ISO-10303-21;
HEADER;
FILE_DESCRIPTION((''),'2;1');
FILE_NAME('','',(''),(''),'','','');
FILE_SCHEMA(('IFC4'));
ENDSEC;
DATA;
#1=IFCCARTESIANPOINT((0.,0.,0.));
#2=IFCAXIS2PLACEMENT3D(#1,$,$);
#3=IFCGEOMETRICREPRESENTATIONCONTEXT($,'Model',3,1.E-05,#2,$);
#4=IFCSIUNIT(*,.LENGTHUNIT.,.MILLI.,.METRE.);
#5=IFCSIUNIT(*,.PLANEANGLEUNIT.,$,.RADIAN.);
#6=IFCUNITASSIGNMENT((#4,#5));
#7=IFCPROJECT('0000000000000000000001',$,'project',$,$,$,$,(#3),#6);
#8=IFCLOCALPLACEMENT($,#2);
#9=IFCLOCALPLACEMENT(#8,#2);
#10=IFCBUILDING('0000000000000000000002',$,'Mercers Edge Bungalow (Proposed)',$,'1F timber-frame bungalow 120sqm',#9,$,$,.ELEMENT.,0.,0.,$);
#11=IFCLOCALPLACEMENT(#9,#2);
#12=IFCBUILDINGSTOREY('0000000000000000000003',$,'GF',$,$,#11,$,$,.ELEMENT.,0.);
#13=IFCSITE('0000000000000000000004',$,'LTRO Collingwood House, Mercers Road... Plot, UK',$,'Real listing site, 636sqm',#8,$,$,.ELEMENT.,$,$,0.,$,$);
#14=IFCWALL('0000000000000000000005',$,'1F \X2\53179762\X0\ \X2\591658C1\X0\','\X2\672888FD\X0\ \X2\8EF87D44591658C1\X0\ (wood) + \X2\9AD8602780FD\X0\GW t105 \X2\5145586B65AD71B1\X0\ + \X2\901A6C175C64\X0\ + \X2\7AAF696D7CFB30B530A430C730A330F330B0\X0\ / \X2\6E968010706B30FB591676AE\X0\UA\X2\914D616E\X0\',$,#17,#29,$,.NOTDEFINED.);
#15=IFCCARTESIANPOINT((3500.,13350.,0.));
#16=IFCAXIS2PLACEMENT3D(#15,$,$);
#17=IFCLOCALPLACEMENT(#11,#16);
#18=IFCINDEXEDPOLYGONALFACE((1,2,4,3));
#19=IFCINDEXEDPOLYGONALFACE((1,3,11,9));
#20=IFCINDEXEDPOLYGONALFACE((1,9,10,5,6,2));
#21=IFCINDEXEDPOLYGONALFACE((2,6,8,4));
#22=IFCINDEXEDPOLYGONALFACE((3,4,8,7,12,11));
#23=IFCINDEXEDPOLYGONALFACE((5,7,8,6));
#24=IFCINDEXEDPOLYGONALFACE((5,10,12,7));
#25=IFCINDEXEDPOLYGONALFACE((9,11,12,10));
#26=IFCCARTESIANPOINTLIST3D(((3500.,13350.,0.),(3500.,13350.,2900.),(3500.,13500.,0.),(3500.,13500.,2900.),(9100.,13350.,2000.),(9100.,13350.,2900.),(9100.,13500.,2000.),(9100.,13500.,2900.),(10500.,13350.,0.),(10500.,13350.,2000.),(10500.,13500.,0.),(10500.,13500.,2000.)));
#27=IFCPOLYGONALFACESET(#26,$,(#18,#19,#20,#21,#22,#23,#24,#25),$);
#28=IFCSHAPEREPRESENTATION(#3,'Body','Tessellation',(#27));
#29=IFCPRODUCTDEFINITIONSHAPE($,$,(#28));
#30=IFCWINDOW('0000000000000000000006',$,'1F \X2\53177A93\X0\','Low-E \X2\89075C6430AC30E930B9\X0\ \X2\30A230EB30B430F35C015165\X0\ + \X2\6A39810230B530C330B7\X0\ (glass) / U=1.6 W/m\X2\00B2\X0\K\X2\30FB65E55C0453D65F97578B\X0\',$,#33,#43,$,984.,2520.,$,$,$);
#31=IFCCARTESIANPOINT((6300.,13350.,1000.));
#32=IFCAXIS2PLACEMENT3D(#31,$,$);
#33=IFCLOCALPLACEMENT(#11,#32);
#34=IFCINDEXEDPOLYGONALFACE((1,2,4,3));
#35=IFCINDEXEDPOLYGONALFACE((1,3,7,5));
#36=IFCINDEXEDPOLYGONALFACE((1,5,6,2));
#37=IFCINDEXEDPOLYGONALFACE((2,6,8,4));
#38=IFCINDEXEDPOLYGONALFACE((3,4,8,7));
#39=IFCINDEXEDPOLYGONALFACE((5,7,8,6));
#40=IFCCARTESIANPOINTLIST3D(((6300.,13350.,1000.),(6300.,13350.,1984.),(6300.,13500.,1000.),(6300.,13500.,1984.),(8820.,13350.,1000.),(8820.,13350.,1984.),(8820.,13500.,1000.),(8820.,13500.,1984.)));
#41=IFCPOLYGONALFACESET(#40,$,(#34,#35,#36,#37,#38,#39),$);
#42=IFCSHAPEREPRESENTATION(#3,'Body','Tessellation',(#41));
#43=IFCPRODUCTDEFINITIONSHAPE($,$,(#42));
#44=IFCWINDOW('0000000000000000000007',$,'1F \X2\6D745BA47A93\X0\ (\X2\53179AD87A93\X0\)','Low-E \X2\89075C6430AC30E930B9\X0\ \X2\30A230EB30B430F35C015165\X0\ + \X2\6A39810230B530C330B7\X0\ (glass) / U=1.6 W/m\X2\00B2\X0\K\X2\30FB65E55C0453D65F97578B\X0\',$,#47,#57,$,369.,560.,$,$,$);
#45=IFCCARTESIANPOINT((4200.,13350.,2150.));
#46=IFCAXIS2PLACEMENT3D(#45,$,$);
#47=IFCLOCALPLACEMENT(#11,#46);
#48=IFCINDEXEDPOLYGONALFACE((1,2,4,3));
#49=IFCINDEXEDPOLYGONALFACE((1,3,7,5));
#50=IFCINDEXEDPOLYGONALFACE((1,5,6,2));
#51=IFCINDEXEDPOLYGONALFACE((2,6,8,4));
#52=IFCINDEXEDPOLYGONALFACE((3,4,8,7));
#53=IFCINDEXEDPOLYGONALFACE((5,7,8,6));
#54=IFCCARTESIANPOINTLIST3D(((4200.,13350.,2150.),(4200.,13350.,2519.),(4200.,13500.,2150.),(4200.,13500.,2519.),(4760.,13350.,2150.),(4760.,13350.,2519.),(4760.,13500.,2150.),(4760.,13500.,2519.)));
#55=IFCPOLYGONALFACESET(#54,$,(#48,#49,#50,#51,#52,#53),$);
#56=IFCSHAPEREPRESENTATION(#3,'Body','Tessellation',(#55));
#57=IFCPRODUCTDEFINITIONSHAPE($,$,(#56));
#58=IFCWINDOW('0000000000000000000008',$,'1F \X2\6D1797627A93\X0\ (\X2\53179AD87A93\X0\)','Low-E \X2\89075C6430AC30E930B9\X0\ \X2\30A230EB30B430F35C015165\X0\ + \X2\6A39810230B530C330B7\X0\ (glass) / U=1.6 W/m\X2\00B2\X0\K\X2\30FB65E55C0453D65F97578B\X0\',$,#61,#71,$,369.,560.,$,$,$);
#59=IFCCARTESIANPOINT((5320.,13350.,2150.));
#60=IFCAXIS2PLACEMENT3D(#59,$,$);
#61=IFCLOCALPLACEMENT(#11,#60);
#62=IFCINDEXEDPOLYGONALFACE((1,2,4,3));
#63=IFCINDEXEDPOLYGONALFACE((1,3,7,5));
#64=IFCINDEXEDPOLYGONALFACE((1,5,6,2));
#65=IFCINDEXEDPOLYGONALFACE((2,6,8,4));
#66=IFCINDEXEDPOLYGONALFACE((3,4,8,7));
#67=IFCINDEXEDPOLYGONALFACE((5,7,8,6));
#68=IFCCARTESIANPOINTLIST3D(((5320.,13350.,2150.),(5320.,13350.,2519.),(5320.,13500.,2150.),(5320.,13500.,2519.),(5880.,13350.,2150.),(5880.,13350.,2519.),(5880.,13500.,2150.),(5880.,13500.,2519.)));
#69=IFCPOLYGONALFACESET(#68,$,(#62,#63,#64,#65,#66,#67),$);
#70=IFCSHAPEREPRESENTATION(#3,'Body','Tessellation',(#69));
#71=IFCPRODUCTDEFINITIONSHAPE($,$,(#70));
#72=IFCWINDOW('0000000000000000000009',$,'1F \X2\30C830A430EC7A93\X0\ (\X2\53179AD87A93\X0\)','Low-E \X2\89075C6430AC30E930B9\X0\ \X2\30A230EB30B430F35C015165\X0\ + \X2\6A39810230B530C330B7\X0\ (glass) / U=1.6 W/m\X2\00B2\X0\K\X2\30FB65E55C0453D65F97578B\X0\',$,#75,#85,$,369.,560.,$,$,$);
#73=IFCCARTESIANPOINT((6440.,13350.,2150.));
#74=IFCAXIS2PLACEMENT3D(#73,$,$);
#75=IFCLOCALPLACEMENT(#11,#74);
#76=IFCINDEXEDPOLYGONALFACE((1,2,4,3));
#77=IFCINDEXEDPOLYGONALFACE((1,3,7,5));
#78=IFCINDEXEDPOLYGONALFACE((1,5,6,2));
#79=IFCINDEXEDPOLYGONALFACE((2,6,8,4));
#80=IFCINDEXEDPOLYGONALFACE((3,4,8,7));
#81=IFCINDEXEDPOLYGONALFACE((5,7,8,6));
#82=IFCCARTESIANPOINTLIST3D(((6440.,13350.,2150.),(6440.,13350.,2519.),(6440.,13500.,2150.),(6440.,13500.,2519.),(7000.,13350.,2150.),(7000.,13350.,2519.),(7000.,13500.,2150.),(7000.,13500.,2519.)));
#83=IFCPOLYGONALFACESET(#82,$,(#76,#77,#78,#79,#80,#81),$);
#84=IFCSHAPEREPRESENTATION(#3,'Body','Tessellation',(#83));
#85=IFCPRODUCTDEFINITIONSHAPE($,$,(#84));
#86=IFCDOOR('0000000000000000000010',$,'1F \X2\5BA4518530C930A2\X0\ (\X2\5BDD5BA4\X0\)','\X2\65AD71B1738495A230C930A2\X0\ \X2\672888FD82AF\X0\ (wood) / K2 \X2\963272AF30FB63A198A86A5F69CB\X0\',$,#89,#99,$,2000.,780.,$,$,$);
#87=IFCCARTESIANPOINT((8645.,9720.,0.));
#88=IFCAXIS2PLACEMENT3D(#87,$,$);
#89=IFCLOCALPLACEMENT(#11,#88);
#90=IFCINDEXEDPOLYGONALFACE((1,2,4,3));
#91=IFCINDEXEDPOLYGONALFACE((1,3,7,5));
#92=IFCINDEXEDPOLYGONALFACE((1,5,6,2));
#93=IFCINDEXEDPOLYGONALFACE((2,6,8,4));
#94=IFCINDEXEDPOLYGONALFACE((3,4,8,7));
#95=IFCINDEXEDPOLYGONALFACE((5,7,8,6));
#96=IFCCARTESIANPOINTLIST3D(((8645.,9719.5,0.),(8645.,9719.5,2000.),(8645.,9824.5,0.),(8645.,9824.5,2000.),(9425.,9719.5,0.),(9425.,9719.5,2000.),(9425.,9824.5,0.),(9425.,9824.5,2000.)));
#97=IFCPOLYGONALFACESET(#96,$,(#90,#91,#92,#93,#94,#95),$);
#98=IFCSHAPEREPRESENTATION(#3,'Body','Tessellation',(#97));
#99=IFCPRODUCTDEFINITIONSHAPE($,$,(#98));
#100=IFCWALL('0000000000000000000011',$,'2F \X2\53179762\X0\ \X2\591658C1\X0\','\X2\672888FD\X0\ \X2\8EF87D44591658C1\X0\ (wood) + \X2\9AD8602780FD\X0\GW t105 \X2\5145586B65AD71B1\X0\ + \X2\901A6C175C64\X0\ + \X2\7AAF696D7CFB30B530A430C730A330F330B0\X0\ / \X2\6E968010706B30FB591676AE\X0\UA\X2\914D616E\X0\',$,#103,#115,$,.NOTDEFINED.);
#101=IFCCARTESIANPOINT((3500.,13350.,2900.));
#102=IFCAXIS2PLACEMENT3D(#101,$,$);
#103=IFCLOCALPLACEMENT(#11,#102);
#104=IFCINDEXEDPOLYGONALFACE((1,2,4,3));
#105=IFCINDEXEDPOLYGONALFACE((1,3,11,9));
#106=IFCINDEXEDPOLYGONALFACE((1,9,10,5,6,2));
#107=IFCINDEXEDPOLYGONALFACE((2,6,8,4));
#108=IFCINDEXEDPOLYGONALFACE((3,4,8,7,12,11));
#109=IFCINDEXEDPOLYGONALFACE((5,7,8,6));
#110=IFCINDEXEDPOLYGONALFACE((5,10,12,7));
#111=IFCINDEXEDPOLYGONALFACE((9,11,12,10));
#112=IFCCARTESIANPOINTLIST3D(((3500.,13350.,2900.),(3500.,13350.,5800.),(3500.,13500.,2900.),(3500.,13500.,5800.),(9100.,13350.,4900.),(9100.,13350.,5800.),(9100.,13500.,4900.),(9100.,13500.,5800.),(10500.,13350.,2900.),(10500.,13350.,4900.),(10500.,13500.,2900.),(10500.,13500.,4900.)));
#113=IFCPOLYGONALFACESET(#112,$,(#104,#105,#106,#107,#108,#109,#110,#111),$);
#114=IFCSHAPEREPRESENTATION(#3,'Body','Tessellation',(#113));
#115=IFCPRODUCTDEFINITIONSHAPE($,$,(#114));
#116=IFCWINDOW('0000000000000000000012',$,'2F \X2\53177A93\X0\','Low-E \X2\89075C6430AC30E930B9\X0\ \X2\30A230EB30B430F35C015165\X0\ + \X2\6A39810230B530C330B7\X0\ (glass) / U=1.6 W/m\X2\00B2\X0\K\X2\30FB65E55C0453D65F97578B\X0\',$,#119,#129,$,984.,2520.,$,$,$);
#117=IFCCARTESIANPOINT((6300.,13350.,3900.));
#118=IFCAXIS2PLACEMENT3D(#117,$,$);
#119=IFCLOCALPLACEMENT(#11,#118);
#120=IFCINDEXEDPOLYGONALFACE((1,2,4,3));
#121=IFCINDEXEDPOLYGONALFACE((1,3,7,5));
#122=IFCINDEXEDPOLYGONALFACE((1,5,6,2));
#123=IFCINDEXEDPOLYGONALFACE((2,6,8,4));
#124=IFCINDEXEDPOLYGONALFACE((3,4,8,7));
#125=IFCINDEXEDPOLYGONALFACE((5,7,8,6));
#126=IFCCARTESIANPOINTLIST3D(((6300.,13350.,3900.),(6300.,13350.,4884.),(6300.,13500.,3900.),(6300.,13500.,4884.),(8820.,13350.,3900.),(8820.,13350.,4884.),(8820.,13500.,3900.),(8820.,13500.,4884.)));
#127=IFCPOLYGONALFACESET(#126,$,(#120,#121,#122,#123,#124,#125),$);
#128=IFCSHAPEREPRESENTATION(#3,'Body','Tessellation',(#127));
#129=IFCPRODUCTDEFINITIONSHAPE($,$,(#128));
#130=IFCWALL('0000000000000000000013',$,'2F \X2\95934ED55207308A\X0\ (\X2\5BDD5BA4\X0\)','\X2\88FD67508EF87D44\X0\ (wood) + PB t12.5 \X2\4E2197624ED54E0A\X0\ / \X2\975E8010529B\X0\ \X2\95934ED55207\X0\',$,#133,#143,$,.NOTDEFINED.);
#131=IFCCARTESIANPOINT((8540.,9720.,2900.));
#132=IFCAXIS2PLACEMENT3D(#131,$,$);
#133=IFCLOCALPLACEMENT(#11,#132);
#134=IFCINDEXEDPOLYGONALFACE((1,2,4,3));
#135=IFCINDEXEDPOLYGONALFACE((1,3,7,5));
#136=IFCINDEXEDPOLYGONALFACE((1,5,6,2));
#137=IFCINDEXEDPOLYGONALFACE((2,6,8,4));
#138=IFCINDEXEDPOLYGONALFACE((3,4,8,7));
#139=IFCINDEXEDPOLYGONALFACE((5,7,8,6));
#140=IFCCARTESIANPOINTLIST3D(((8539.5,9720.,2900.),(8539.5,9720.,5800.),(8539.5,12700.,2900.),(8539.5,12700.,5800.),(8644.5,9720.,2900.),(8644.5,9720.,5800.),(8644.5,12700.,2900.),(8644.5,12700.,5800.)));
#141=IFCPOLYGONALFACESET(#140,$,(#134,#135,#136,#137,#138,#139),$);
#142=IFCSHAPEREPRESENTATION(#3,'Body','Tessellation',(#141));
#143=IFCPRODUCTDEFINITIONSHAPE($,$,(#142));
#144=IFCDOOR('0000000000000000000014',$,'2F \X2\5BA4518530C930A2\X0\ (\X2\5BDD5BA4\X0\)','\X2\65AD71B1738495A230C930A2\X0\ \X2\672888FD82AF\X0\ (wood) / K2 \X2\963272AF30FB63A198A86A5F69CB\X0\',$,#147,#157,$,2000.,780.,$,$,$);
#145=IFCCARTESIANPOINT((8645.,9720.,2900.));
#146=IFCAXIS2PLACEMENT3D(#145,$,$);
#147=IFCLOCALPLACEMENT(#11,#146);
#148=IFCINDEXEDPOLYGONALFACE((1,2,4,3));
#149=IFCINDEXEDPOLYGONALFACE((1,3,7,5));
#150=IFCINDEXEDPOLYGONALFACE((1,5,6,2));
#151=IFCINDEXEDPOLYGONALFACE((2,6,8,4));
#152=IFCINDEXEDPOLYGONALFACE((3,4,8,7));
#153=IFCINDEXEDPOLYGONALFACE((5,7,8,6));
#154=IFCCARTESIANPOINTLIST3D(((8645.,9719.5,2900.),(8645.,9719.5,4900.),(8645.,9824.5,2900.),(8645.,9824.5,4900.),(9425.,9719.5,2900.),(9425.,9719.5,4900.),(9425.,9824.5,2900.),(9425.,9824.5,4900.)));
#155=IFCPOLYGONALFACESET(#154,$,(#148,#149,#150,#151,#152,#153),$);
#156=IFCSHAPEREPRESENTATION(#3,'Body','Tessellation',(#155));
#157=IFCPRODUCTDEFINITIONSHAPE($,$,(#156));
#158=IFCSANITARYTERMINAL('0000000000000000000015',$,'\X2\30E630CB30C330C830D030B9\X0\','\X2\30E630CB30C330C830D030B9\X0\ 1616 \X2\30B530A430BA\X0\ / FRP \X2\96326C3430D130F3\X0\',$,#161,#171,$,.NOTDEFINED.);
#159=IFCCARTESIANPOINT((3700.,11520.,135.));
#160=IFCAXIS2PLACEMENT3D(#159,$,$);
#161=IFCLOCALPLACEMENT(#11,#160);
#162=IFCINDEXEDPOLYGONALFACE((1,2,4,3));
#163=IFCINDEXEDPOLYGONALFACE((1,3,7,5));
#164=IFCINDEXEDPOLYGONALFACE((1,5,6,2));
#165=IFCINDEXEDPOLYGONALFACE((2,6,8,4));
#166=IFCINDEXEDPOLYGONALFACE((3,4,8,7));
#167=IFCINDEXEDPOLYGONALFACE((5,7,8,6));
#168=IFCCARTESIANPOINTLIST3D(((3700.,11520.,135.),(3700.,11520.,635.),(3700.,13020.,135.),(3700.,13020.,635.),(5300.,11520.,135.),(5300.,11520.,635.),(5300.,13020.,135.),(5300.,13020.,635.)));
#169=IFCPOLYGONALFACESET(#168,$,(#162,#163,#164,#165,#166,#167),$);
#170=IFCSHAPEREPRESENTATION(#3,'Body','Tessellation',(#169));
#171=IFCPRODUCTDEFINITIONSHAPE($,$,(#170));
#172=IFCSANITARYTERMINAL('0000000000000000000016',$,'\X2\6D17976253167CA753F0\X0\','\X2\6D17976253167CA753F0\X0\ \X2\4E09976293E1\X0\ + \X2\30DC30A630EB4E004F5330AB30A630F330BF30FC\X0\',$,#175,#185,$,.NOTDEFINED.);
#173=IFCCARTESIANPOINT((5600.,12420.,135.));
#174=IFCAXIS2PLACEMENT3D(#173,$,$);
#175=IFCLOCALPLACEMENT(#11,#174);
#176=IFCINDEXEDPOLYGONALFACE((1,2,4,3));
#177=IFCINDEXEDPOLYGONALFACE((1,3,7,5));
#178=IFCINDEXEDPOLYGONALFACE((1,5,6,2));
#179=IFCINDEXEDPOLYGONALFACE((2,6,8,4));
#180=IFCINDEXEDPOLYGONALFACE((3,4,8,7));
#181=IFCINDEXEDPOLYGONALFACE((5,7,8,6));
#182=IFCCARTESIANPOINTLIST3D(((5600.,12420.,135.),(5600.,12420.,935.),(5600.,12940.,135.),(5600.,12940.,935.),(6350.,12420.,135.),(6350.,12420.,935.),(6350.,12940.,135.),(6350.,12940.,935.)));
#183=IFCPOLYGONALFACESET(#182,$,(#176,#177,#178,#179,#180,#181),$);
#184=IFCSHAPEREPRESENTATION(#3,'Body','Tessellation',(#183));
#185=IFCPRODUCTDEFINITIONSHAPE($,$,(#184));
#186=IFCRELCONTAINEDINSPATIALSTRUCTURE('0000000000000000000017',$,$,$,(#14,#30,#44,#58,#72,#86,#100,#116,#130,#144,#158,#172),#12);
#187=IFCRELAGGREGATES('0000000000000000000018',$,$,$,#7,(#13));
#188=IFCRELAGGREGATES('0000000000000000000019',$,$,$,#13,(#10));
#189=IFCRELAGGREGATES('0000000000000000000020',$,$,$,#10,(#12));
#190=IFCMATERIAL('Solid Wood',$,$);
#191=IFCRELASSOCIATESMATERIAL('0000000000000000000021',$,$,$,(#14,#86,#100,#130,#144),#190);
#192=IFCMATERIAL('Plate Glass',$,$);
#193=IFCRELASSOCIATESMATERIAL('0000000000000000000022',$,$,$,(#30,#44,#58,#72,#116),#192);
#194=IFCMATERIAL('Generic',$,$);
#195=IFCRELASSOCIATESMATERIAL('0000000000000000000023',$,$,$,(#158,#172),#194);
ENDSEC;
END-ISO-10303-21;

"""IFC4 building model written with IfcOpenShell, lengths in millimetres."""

from ifc_helpers import new_model, si_unit, frame, frame_2d, origin, place, context, project, spatial, rectangle, extrude, material, element, fill, save


model = new_model("IFC4")

# Units and contexts
model_context = context("Model", 3, precision=1e-05, world=origin())
ifc_project = project(units=[si_unit("LENGTHUNIT", "METRE", prefix="MILLI"), si_unit("PLANEANGLEUNIT", "RADIAN")], contexts=[model_context])

# Site, building, storey
site_placement = place(None, origin())
site = spatial("IfcSite", under=ifc_project, at=site_placement, Name="LTRO Collingwood House, Mercers Road... Plot, UK", ObjectType="Real listing site, 636sqm", CompositionType="ELEMENT", RefElevation=0.0)
building_placement = place(site_placement, origin())
building = spatial("IfcBuilding", under=site, at=building_placement, Name="Mercers Edge Bungalow (Proposed)", ObjectType="1F timber-frame bungalow 120sqm", CompositionType="ELEMENT", ElevationOfRefHeight=0.0, ElevationOfTerrain=0.0)
storey_placement = place(building_placement, origin())
storey = spatial("IfcBuildingStorey", under=building, at=storey_placement, Name="GF", CompositionType="ELEMENT", Elevation=0.0)

# Wall, openings, windows
ifc_material_1 = material(Name="Solid Wood")
wall_1_placement = place(storey_placement, frame((3500.0, 13350.0, 0.0)))
wall_1 = element("IfcWall", 1, at=wall_1_placement, inside=storey, material=ifc_material_1, Name="1F 北面 外壁", Description="木製 軸組外壁 (wood) + 高性能GW t105 充填断熱 + 通気層 + 窯業系サイディング / 準耐火・外皮UA配慮", PredefinedType="NOTDEFINED", context=model_context, shape_type="SweptSolid", body=[
    extrude(rectangle(XDim=7000.0, YDim=150.0, at=frame_2d((3500.0, 75.0))), frame((3500.0, 13350.0, 0.0)), (0.0, 0.0, 1.0), 2900.0),
])
opening_1_placement = place(storey_placement, frame((6300.0, 13350.0, 1000.0)))
opening_1 = element("IfcOpeningElement", 2, at=opening_1_placement, cuts=wall_1, PredefinedType="NOTDEFINED", context=model_context, shape_type="SweptSolid", body=[
    extrude(rectangle(XDim=2520.0, YDim=150.0, at=frame_2d((1260.0, 75.0))), frame((6300.0, 13350.0, 1000.0)), (0.0, 0.0, 1.0), 984.0),
])
opening_2_placement = place(storey_placement, frame((4200.0, 13350.0, 2150.0)))
opening_2 = element("IfcOpeningElement", 3, at=opening_2_placement, cuts=wall_1, PredefinedType="NOTDEFINED", context=model_context, shape_type="SweptSolid", body=[
    extrude(rectangle(XDim=560.0, YDim=150.0, at=frame_2d((280.0, 75.0))), frame((4200.0, 13350.0, 2150.0)), (0.0, 0.0, 1.0), 369.0),
])
opening_3_placement = place(storey_placement, frame((5320.0, 13350.0, 2150.0)))
opening_3 = element("IfcOpeningElement", 4, at=opening_3_placement, cuts=wall_1, PredefinedType="NOTDEFINED", context=model_context, shape_type="SweptSolid", body=[
    extrude(rectangle(XDim=560.0, YDim=150.0, at=frame_2d((280.0, 75.0))), frame((5320.0, 13350.0, 2150.0)), (0.0, 0.0, 1.0), 369.0),
])
opening_4_placement = place(storey_placement, frame((6440.0, 13350.0, 2150.0)))
opening_4 = element("IfcOpeningElement", 5, at=opening_4_placement, cuts=wall_1, PredefinedType="NOTDEFINED", context=model_context, shape_type="SweptSolid", body=[
    extrude(rectangle(XDim=560.0, YDim=150.0, at=frame_2d((280.0, 75.0))), frame((6440.0, 13350.0, 2150.0)), (0.0, 0.0, 1.0), 369.0),
])
ifc_material_2 = material(Name="Plate Glass")
window_1_placement = place(storey_placement, frame((6300.0, 13350.0, 1000.0)))
window_1 = element("IfcWindow", 6, at=window_1_placement, inside=storey, material=ifc_material_2, Name="1F 北窓", Description="Low-E 複層ガラス アルゴン封入 + 樹脂サッシ (glass) / U=1.6 W/m²K・日射取得型", OverallHeight=984.0, OverallWidth=2520.0, context=model_context, shape_type="SweptSolid", body=[
    extrude(rectangle(XDim=2520.0, YDim=150.0, at=frame_2d((1260.0, 75.0))), frame((6300.0, 13350.0, 1000.0)), (0.0, 0.0, 1.0), 984.0),
])
fill(opening_1, window_1)
window_2_placement = place(storey_placement, frame((4200.0, 13350.0, 2150.0)))
window_2 = element("IfcWindow", 7, at=window_2_placement, inside=storey, material=ifc_material_2, Name="1F 浴室窓 (北高窓)", Description="Low-E 複層ガラス アルゴン封入 + 樹脂サッシ (glass) / U=1.6 W/m²K・日射取得型", OverallHeight=369.0, OverallWidth=560.0, context=model_context, shape_type="SweptSolid", body=[
    extrude(rectangle(XDim=560.0, YDim=150.0, at=frame_2d((280.0, 75.0))), frame((4200.0, 13350.0, 2150.0)), (0.0, 0.0, 1.0), 369.0),
])
fill(opening_2, window_2)
window_3_placement = place(storey_placement, frame((5320.0, 13350.0, 2150.0)))
window_3 = element("IfcWindow", 8, at=window_3_placement, inside=storey, material=ifc_material_2, Name="1F 洗面窓 (北高窓)", Description="Low-E 複層ガラス アルゴン封入 + 樹脂サッシ (glass) / U=1.6 W/m²K・日射取得型", OverallHeight=369.0, OverallWidth=560.0, context=model_context, shape_type="SweptSolid", body=[
    extrude(rectangle(XDim=560.0, YDim=150.0, at=frame_2d((280.0, 75.0))), frame((5320.0, 13350.0, 2150.0)), (0.0, 0.0, 1.0), 369.0),
])
fill(opening_3, window_3)
window_4_placement = place(storey_placement, frame((6440.0, 13350.0, 2150.0)))
window_4 = element("IfcWindow", 9, at=window_4_placement, inside=storey, material=ifc_material_2, Name="1F トイレ窓 (北高窓)", Description="Low-E 複層ガラス アルゴン封入 + 樹脂サッシ (glass) / U=1.6 W/m²K・日射取得型", OverallHeight=369.0, OverallWidth=560.0, context=model_context, shape_type="SweptSolid", body=[
    extrude(rectangle(XDim=560.0, YDim=150.0, at=frame_2d((280.0, 75.0))), frame((6440.0, 13350.0, 2150.0)), (0.0, 0.0, 1.0), 369.0),
])
fill(opening_4, window_4)

# Door
door_1_placement = place(storey_placement, frame((8645.0, 9720.0, 0.0)))
element("IfcDoor", 10, at=door_1_placement, inside=storey, material=ifc_material_1, Name="1F 室内ドア (寝室)", Description="断熱玄関ドア 木製芯 (wood) / K2 防犯・採風機構", OverallHeight=2000.0, OverallWidth=780.0, context=model_context, shape_type="SweptSolid", body=[
    extrude(rectangle(XDim=780.0, YDim=105.0, at=frame_2d((390.0, 52.0))), frame((8645.0, 9720.0, 0.0)), (0.0, 0.0, 1.0), 2000.0),
])

# Wall, opening, window
wall_2_placement = place(storey_placement, frame((3500.0, 13350.0, 2900.0)))
wall_2 = element("IfcWall", 11, at=wall_2_placement, inside=storey, material=ifc_material_1, Name="2F 北面 外壁", Description="木製 軸組外壁 (wood) + 高性能GW t105 充填断熱 + 通気層 + 窯業系サイディング / 準耐火・外皮UA配慮", PredefinedType="NOTDEFINED", context=model_context, shape_type="SweptSolid", body=[
    extrude(rectangle(XDim=7000.0, YDim=150.0, at=frame_2d((3500.0, 75.0))), frame((3500.0, 13350.0, 2900.0)), (0.0, 0.0, 1.0), 2900.0),
])
opening_5_placement = place(storey_placement, frame((6300.0, 13350.0, 3900.0)))
opening_5 = element("IfcOpeningElement", 12, at=opening_5_placement, cuts=wall_2, PredefinedType="NOTDEFINED", context=model_context, shape_type="SweptSolid", body=[
    extrude(rectangle(XDim=2520.0, YDim=150.0, at=frame_2d((1260.0, 75.0))), frame((6300.0, 13350.0, 3900.0)), (0.0, 0.0, 1.0), 984.0),
])
window_5_placement = place(storey_placement, frame((6300.0, 13350.0, 3900.0)))
window_5 = element("IfcWindow", 13, at=window_5_placement, inside=storey, material=ifc_material_2, Name="2F 北窓", Description="Low-E 複層ガラス アルゴン封入 + 樹脂サッシ (glass) / U=1.6 W/m²K・日射取得型", OverallHeight=984.0, OverallWidth=2520.0, context=model_context, shape_type="SweptSolid", body=[
    extrude(rectangle(XDim=2520.0, YDim=150.0, at=frame_2d((1260.0, 75.0))), frame((6300.0, 13350.0, 3900.0)), (0.0, 0.0, 1.0), 984.0),
])
fill(opening_5, window_5)

# Wall
wall_3_placement = place(storey_placement, frame((8540.0, 9720.0, 2900.0)))
element("IfcWall", 14, at=wall_3_placement, inside=storey, material=ifc_material_1, Name="2F 間仕切り (寝室)", Description="製材軸組 (wood) + PB t12.5 両面仕上 / 非耐力 間仕切", PredefinedType="NOTDEFINED", context=model_context, shape_type="SweptSolid", body=[
    extrude(rectangle(XDim=105.0, YDim=2980.0, at=frame_2d((52.0, 1490.0))), frame((8540.0, 9720.0, 2900.0)), (0.0, 0.0, 1.0), 2900.0),
])

# Door
door_2_placement = place(storey_placement, frame((8645.0, 9720.0, 2900.0)))
element("IfcDoor", 15, at=door_2_placement, inside=storey, material=ifc_material_1, Name="2F 室内ドア (寝室)", Description="断熱玄関ドア 木製芯 (wood) / K2 防犯・採風機構", OverallHeight=2000.0, OverallWidth=780.0, context=model_context, shape_type="SweptSolid", body=[
    extrude(rectangle(XDim=780.0, YDim=105.0, at=frame_2d((390.0, 52.0))), frame((8645.0, 9720.0, 2900.0)), (0.0, 0.0, 1.0), 2000.0),
])

# Sanitary terminals
ifc_material_3 = material(Name="Generic")
sanitary_terminal_1_placement = place(storey_placement, frame((3700.0, 11520.0, 135.0)))
element("IfcSanitaryTerminal", 16, at=sanitary_terminal_1_placement, inside=storey, material=ifc_material_3, Name="ユニットバス", Description="ユニットバス 1616 サイズ / FRP 防水パン", PredefinedType="NOTDEFINED", context=model_context, shape_type="SweptSolid", body=[
    extrude(rectangle(XDim=1600.0, YDim=1500.0, at=frame_2d((800.0, 750.0))), frame((3700.0, 11520.0, 135.0)), (0.0, 0.0, 1.0), 500.0),
])
sanitary_terminal_2_placement = place(storey_placement, frame((5600.0, 12420.0, 135.0)))
element("IfcSanitaryTerminal", 17, at=sanitary_terminal_2_placement, inside=storey, material=ifc_material_3, Name="洗面化粧台", Description="洗面化粧台 三面鏡 + ボウル一体カウンター", PredefinedType="NOTDEFINED", context=model_context, shape_type="SweptSolid", body=[
    extrude(rectangle(XDim=750.0, YDim=520.0, at=frame_2d((375.0, 260.0))), frame((5600.0, 12420.0, 135.0)), (0.0, 0.0, 1.0), 800.0),
])

save(model, "model.ifc")
